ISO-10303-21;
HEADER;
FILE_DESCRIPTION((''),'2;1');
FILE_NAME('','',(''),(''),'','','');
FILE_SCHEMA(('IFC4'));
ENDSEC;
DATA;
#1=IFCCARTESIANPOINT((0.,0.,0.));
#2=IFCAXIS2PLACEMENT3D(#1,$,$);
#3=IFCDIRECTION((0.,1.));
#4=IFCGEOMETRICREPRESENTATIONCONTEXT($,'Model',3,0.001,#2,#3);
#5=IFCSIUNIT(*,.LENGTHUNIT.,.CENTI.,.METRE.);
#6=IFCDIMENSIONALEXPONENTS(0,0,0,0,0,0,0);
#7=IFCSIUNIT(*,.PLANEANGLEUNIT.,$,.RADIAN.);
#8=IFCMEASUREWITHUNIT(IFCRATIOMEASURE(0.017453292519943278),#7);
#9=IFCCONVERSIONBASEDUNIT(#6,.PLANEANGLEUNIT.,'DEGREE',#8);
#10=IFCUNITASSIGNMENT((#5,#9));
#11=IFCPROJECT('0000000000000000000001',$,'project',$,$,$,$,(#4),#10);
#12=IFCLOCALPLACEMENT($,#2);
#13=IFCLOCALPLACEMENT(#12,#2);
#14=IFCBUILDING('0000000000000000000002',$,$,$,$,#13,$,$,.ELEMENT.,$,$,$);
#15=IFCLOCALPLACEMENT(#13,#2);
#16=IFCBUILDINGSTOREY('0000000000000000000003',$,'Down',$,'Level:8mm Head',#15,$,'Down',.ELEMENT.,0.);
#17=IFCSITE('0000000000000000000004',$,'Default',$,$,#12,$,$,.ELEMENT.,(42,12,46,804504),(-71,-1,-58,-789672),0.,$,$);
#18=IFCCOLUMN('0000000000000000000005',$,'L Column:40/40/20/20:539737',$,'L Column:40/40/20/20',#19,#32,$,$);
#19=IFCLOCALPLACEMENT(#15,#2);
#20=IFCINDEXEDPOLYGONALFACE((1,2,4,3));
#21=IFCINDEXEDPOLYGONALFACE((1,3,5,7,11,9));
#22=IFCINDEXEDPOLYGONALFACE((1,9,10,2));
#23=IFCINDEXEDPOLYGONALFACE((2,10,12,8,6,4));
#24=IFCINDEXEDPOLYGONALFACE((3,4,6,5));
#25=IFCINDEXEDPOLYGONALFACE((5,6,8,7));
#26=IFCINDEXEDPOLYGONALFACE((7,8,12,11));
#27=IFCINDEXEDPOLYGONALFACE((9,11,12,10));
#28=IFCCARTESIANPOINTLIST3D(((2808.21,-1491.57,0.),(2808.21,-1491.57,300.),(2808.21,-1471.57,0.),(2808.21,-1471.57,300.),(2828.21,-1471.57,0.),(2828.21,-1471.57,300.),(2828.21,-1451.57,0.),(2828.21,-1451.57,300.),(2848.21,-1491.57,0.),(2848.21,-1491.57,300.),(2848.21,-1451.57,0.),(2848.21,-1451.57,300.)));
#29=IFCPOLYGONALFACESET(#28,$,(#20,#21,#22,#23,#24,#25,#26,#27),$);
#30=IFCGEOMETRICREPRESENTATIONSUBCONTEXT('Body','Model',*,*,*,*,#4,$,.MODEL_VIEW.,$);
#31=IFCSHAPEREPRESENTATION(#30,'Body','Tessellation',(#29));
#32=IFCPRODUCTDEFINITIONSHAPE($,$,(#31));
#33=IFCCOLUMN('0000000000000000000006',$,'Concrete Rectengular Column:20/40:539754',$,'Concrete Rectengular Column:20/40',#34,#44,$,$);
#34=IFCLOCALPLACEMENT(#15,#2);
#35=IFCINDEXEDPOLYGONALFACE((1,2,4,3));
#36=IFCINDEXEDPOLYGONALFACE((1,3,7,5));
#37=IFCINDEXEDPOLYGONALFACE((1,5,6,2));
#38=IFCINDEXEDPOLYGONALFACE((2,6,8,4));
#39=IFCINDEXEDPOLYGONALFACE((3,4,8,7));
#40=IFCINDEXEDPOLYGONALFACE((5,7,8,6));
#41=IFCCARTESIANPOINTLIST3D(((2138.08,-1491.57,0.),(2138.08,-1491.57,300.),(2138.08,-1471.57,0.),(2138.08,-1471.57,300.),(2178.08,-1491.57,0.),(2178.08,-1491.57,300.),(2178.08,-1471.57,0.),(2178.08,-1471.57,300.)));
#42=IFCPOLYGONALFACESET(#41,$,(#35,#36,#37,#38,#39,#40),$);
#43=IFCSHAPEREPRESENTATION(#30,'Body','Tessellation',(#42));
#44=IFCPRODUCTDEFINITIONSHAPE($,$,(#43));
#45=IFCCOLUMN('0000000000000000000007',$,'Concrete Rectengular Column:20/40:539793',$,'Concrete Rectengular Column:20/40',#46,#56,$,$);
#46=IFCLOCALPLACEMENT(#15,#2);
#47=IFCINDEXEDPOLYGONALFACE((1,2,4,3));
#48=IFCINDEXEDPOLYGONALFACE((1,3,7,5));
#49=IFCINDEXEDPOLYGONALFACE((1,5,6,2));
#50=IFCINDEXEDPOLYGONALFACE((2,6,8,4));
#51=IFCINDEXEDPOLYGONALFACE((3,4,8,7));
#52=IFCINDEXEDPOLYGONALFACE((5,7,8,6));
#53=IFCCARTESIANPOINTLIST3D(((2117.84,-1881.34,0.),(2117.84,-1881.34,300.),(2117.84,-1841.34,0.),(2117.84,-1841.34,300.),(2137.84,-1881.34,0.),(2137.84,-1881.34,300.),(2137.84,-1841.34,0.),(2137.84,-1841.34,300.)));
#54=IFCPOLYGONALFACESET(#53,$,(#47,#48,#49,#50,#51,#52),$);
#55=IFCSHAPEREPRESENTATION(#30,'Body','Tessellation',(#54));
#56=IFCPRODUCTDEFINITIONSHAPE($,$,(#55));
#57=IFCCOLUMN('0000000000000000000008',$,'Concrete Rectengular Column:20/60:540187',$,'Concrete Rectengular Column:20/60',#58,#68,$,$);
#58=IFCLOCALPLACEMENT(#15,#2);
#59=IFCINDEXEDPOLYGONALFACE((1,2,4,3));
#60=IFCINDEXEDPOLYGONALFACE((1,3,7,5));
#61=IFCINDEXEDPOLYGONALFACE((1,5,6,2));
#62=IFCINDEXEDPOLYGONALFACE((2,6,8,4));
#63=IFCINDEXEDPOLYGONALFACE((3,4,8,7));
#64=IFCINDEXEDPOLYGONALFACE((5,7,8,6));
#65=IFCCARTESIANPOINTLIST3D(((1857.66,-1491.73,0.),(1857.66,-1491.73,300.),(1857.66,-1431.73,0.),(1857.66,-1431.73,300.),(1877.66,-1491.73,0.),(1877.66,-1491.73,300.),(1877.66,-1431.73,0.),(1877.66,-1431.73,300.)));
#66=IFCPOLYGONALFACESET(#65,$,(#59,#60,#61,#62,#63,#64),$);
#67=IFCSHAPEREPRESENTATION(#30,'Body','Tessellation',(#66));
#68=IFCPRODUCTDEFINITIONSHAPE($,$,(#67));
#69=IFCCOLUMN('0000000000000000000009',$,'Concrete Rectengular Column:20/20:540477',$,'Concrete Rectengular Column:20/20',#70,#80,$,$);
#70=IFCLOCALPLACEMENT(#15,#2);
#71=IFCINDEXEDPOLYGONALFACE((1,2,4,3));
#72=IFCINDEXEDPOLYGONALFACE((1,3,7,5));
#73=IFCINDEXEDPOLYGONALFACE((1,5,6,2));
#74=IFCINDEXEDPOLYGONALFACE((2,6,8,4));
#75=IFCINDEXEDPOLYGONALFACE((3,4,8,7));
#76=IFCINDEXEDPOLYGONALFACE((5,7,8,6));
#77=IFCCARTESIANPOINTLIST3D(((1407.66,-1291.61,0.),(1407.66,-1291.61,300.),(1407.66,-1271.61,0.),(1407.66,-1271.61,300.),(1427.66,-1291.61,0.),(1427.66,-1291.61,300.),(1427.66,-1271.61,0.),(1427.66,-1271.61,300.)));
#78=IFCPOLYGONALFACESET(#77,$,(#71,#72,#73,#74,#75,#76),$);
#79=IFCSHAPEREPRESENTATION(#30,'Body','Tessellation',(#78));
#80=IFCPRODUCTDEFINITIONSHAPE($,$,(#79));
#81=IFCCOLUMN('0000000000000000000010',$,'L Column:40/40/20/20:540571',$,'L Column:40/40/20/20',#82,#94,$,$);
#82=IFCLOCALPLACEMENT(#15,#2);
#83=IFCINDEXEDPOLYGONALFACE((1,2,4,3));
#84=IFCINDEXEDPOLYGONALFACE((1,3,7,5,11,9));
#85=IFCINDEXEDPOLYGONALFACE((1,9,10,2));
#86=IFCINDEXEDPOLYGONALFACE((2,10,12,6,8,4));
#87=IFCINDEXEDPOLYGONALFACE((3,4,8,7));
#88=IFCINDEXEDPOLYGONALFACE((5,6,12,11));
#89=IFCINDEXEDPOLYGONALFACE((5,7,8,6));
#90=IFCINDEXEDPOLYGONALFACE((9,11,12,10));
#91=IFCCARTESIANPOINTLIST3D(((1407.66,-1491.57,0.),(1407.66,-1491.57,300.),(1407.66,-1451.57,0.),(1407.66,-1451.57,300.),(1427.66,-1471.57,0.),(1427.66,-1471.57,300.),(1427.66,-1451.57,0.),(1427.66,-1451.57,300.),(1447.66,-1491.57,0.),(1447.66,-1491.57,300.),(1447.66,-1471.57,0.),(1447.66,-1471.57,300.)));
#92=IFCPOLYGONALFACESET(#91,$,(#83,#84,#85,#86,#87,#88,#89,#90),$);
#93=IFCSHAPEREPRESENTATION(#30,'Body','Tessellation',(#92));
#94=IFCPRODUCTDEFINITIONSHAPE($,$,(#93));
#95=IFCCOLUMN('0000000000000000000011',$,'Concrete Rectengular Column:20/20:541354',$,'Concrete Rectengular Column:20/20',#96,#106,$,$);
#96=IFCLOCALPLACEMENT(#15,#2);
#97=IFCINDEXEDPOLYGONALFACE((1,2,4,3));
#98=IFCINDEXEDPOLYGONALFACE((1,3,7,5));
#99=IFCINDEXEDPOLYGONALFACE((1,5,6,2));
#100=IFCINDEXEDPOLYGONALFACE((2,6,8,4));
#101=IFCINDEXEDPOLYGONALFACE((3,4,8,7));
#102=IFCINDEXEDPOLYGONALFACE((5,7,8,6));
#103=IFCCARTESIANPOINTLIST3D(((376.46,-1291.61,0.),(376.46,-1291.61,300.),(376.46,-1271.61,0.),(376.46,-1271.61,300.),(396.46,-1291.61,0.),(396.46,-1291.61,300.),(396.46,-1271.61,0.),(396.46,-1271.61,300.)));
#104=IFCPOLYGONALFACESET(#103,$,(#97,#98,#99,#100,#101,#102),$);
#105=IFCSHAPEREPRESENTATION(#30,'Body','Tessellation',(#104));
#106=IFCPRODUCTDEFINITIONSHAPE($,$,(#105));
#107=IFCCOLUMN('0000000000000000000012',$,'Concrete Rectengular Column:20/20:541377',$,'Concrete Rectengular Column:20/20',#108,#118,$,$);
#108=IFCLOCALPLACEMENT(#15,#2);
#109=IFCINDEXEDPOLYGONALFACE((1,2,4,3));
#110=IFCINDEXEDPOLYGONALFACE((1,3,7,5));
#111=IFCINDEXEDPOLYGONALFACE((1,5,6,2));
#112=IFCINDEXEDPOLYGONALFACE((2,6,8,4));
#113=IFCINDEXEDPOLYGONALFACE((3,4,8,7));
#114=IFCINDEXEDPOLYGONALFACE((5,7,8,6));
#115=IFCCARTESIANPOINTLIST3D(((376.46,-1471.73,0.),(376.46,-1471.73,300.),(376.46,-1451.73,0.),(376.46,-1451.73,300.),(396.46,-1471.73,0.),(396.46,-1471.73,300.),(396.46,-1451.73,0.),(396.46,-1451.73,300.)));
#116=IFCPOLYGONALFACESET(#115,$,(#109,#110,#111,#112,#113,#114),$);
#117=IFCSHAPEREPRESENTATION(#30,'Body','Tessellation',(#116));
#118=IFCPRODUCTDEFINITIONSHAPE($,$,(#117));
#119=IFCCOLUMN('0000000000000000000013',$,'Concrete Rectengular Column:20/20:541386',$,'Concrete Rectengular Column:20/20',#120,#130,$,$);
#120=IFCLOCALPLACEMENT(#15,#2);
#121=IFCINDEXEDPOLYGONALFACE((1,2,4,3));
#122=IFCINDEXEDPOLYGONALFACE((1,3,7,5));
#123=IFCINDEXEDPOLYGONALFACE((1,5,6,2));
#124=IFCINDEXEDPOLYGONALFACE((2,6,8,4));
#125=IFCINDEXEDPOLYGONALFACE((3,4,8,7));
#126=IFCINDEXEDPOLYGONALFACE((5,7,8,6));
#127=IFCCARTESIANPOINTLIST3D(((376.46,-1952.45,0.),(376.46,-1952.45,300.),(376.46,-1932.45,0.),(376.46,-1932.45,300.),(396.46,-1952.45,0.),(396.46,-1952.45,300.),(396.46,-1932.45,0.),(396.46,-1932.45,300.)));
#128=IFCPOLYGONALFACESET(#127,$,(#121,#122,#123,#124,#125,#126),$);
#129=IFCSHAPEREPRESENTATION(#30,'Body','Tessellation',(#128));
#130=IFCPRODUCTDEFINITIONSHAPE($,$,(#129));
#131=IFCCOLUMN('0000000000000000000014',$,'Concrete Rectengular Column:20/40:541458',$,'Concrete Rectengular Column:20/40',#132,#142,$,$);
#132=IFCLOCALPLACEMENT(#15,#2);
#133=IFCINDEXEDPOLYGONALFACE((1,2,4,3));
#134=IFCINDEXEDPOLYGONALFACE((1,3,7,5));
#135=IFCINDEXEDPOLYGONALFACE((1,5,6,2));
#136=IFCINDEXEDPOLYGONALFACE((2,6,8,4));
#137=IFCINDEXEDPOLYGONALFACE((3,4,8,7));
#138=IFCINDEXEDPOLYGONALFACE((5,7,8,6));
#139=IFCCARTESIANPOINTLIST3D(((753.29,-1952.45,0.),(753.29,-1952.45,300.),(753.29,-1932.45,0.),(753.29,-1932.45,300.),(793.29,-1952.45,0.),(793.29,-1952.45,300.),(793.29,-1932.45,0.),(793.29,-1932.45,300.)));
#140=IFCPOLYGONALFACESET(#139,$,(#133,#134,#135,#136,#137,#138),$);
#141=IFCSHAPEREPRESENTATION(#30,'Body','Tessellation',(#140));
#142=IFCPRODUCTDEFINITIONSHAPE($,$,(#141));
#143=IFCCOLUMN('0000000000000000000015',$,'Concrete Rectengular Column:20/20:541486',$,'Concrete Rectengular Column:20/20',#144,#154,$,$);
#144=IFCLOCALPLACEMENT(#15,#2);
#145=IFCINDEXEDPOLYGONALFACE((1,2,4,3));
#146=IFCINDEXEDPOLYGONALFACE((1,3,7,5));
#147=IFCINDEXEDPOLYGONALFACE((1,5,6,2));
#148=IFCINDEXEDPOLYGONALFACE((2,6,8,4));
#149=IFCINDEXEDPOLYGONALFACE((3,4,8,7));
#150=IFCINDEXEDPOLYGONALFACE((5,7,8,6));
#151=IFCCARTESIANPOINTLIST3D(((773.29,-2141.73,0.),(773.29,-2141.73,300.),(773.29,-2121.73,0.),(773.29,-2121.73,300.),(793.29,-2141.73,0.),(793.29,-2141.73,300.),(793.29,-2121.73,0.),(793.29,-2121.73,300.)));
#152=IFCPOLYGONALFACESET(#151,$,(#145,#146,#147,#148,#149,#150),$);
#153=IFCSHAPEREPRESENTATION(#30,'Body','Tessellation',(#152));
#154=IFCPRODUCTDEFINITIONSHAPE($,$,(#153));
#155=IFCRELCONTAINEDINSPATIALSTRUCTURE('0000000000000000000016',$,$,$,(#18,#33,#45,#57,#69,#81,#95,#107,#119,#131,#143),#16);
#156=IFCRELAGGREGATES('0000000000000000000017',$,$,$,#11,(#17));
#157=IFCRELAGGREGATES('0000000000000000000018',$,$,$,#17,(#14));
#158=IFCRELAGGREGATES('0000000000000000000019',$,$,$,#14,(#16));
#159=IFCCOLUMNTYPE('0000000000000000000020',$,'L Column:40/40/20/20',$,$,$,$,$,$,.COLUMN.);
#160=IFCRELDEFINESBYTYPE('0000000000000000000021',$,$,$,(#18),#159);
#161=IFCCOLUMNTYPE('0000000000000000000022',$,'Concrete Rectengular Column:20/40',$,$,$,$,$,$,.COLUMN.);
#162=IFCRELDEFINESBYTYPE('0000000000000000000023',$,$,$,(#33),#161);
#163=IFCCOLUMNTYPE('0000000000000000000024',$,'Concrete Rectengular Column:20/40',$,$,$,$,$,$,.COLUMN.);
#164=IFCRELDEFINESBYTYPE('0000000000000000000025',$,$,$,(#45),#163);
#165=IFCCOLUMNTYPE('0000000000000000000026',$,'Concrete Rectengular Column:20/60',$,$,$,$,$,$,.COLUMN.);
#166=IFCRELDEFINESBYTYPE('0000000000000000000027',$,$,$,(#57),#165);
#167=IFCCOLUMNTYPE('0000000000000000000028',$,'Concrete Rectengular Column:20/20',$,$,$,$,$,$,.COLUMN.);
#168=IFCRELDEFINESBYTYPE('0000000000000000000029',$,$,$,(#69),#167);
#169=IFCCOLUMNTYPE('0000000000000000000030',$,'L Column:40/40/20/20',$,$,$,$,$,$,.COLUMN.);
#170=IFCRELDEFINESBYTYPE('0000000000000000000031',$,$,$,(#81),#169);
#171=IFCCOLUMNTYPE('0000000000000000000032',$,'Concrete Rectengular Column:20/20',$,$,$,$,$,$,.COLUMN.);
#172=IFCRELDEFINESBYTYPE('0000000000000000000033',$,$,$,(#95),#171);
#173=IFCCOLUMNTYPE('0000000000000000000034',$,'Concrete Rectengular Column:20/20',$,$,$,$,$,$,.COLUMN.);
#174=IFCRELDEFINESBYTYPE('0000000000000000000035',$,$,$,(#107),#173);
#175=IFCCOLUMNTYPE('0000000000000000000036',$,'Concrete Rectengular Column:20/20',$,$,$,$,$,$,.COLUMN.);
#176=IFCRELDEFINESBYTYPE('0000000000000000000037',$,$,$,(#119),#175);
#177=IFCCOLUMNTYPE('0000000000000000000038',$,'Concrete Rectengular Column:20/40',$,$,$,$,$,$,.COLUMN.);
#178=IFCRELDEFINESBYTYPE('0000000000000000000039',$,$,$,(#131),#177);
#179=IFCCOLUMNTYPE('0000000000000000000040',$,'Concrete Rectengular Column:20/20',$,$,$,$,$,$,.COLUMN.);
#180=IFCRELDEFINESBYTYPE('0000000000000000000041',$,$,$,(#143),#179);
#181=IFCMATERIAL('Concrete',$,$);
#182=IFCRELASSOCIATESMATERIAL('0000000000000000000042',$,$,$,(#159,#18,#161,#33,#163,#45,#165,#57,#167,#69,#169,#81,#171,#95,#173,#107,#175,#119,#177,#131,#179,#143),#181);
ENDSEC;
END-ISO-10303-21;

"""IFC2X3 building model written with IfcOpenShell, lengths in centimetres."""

from ifc_helpers import new_model, entity, si_unit, converted_unit, direction, frame, frame_2d, origin, origin_2d_with_axis, place, context, subcontext, project, spatial, polyline, rectangle, outline, extrude, source, transform, mapped, material, type_object, type_shapes, element, save


model = new_model("IFC2X3")

# Units and contexts
model_context = context("Model", 3, precision=0.001, world=origin(), true_north=direction((0.0, 1.0)))
body_context = subcontext(model_context, "Body", "Model", "MODEL_VIEW")
ifc_project = project(units=[si_unit("LENGTHUNIT", "METRE", prefix="CENTI"), converted_unit("PLANEANGLEUNIT", "DEGREE", entity("IfcRatioMeasure", 0.017453292519943278), si_unit("PLANEANGLEUNIT", "RADIAN"), dimensions=[0, 0, 0, 0, 0, 0, 0])], contexts=[model_context])

# Site, building, storey
site_placement = place(None, origin())
site = spatial("IfcSite", under=ifc_project, at=site_placement, Name="Default", CompositionType="ELEMENT", RefLatitude=(42, 12, 46, 804504), RefLongitude=(-71, -1, -58, -789672), RefElevation=0.0)
building_placement = place(site_placement, origin())
building = spatial("IfcBuilding", under=site, at=building_placement, CompositionType="ELEMENT")
storey_placement = place(building_placement, origin())
storey = spatial("IfcBuildingStorey", under=building, at=storey_placement, Name="Down", ObjectType="Level:8mm Head", LongName="Down", CompositionType="ELEMENT", Elevation=0.0)

# Columns
ifc_material = material(Name="Concrete")
column_type_1 = type_object("IfcColumnType", Name="L Column:40/40/20/20", PredefinedType="COLUMN", material=ifc_material)
shared_shape_1 = source(origin(), body_context, "Body", "SweptSolid", [
    extrude(outline(polyline([(0.0, -20.0), (20.0, -20.0), (20.0, 20.0), (-20.0, 20.0), (-20.0, 0.0), (0.0, 0.0), (0.0, -20.0)])), frame((2828.21, -1471.57, 0.0), z_axis=(0.0, 0.0, 1.0), x_axis=(0.0, -1.0, 0.0)), (0.0, 0.0, 1.0), 300.0),
])
type_shapes(column_type_1, [shared_shape_1])
column_1_placement = place(storey_placement, origin())
element("IfcColumn", 1, at=column_1_placement, inside=storey, type_object=column_type_1, material=ifc_material, Name="L Column:40/40/20/20:539737", ObjectType="L Column:40/40/20/20", context=body_context, shape_type="MappedRepresentation", body=[
    mapped(shared_shape_1, transform((0.0, 0.0, 0.0), scale=1.0)),
])
column_type_2 = type_object("IfcColumnType", Name="Concrete Rectengular Column:20/40", PredefinedType="COLUMN", material=ifc_material)
shared_shape_2 = source(origin(), body_context, "Body", "SweptSolid", [
    extrude(rectangle(XDim=20.0, YDim=40.0, at=frame_2d((0.0, 0.0), x_axis=(1.0, 0.0))), frame((2158.08, -1481.57, 0.0), z_axis=(0.0, 0.0, 1.0), x_axis=(0.0, -1.0, 0.0)), (0.0, 0.0, 1.0), 300.0),
])
type_shapes(column_type_2, [shared_shape_2])
column_2_placement = place(storey_placement, origin())
element("IfcColumn", 2, at=column_2_placement, inside=storey, type_object=column_type_2, material=ifc_material, Name="Concrete Rectengular Column:20/40:539754", ObjectType="Concrete Rectengular Column:20/40", context=body_context, shape_type="MappedRepresentation", body=[
    mapped(shared_shape_2, transform((0.0, 0.0, 0.0), scale=1.0)),
])
column_type_3 = type_object("IfcColumnType", Name="Concrete Rectengular Column:20/40", PredefinedType="COLUMN", material=ifc_material)
shared_shape_3 = source(origin(), body_context, "Body", "SweptSolid", [
    extrude(rectangle(XDim=40.0, YDim=20.0, at=frame_2d((0.0, 0.0), x_axis=(1.0, 0.0))), frame((2127.84, -1861.34, 0.0), z_axis=(0.0, 0.0, 1.0), x_axis=(0.0, -1.0, 0.0)), (0.0, 0.0, 1.0), 300.0),
])
type_shapes(column_type_3, [shared_shape_3])
column_3_placement = place(storey_placement, origin())
element("IfcColumn", 3, at=column_3_placement, inside=storey, type_object=column_type_3, material=ifc_material, Name="Concrete Rectengular Column:20/40:539793", ObjectType="Concrete Rectengular Column:20/40", context=body_context, shape_type="MappedRepresentation", body=[
    mapped(shared_shape_3, transform((0.0, 0.0, 0.0), scale=1.0)),
])
column_type_4 = type_object("IfcColumnType", Name="Concrete Rectengular Column:20/60", PredefinedType="COLUMN", material=ifc_material)
shared_shape_4 = source(origin(), body_context, "Body", "SweptSolid", [
    extrude(rectangle(XDim=60.0, YDim=20.0, at=frame_2d((0.0, 0.0), x_axis=(1.0, 0.0))), frame((1867.66, -1461.73, 0.0), z_axis=(0.0, 0.0, 1.0), x_axis=(0.0, -1.0, 0.0)), (0.0, 0.0, 1.0), 300.0),
])
type_shapes(column_type_4, [shared_shape_4])
column_4_placement = place(storey_placement, origin())
element("IfcColumn", 4, at=column_4_placement, inside=storey, type_object=column_type_4, material=ifc_material, Name="Concrete Rectengular Column:20/60:540187", ObjectType="Concrete Rectengular Column:20/60", context=body_context, shape_type="MappedRepresentation", body=[
    mapped(shared_shape_4, transform((0.0, 0.0, 0.0), scale=1.0)),
])
column_type_5 = type_object("IfcColumnType", Name="Concrete Rectengular Column:20/20", PredefinedType="COLUMN", material=ifc_material)
shared_shape_5 = source(origin(), body_context, "Body", "SweptSolid", [
    extrude(rectangle(XDim=20.0, YDim=20.0, at=frame_2d((0.0, 0.0), x_axis=(1.0, 0.0))), frame((1417.66, -1281.61, 0.0), z_axis=(0.0, 0.0, 1.0), x_axis=(0.0, -1.0, 0.0)), (0.0, 0.0, 1.0), 300.0),
])
type_shapes(column_type_5, [shared_shape_5])
column_5_placement = place(storey_placement, origin())
element("IfcColumn", 5, at=column_5_placement, inside=storey, type_object=column_type_5, material=ifc_material, Name="Concrete Rectengular Column:20/20:540477", ObjectType="Concrete Rectengular Column:20/20", context=body_context, shape_type="MappedRepresentation", body=[
    mapped(shared_shape_5, transform((0.0, 0.0, 0.0), scale=1.0)),
])
column_type_6 = type_object("IfcColumnType", Name="L Column:40/40/20/20", PredefinedType="COLUMN", material=ifc_material)
shared_shape_6 = source(origin(), body_context, "Body", "SweptSolid", [
    extrude(outline(polyline([(-20.0, -20.0), (20.0, -20.0), (20.0, 20.0), (0.0, 20.0), (0.0, 0.0), (-20.0, 0.0), (-20.0, -20.0)])), frame((1427.66, -1471.57, 0.0), z_axis=(0.0, 0.0, 1.0), x_axis=(0.0, -1.0, 0.0)), (0.0, 0.0, 1.0), 300.0),
])
type_shapes(column_type_6, [shared_shape_6])
column_6_placement = place(storey_placement, origin())
element("IfcColumn", 6, at=column_6_placement, inside=storey, type_object=column_type_6, material=ifc_material, Name="L Column:40/40/20/20:540571", ObjectType="L Column:40/40/20/20", context=body_context, shape_type="MappedRepresentation", body=[
    mapped(shared_shape_6, transform((0.0, 0.0, 0.0), scale=1.0)),
])
column_type_7 = type_object("IfcColumnType", Name="Concrete Rectengular Column:20/20", PredefinedType="COLUMN", material=ifc_material)
shared_shape_7 = source(origin(), body_context, "Body", "SweptSolid", [
    extrude(rectangle(XDim=20.0, YDim=20.0, at=frame_2d((0.0, 0.0), x_axis=(1.0, 0.0))), frame((386.46, -1281.61, 0.0), z_axis=(0.0, 0.0, 1.0), x_axis=(0.0, -1.0, 0.0)), (0.0, 0.0, 1.0), 300.0),
])
type_shapes(column_type_7, [shared_shape_7])
column_7_placement = place(storey_placement, origin())
element("IfcColumn", 7, at=column_7_placement, inside=storey, type_object=column_type_7, material=ifc_material, Name="Concrete Rectengular Column:20/20:541354", ObjectType="Concrete Rectengular Column:20/20", context=body_context, shape_type="MappedRepresentation", body=[
    mapped(shared_shape_7, transform((0.0, 0.0, 0.0), scale=1.0)),
])
column_type_8 = type_object("IfcColumnType", Name="Concrete Rectengular Column:20/20", PredefinedType="COLUMN", material=ifc_material)
shared_shape_8 = source(origin(), body_context, "Body", "SweptSolid", [
    extrude(rectangle(XDim=20.0, YDim=20.0, at=frame_2d((0.0, 0.0), x_axis=(1.0, 0.0))), frame((386.46, -1461.73, 0.0), z_axis=(0.0, 0.0, 1.0), x_axis=(0.0, -1.0, 0.0)), (0.0, 0.0, 1.0), 300.0),
])
type_shapes(column_type_8, [shared_shape_8])
column_8_placement = place(storey_placement, origin())
element("IfcColumn", 8, at=column_8_placement, inside=storey, type_object=column_type_8, material=ifc_material, Name="Concrete Rectengular Column:20/20:541377", ObjectType="Concrete Rectengular Column:20/20", context=body_context, shape_type="MappedRepresentation", body=[
    mapped(shared_shape_8, transform((0.0, 0.0, 0.0), scale=1.0)),
])
column_type_9 = type_object("IfcColumnType", Name="Concrete Rectengular Column:20/20", PredefinedType="COLUMN", material=ifc_material)
shared_shape_9 = source(origin(), body_context, "Body", "SweptSolid", [
    extrude(rectangle(XDim=20.0, YDim=20.0, at=frame_2d((0.0, 0.0), x_axis=(1.0, 0.0))), frame((386.46, -1942.45, 0.0), z_axis=(0.0, 0.0, 1.0), x_axis=(0.0, -1.0, 0.0)), (0.0, 0.0, 1.0), 300.0),
])
type_shapes(column_type_9, [shared_shape_9])
column_9_placement = place(storey_placement, origin())
element("IfcColumn", 9, at=column_9_placement, inside=storey, type_object=column_type_9, material=ifc_material, Name="Concrete Rectengular Column:20/20:541386", ObjectType="Concrete Rectengular Column:20/20", context=body_context, shape_type="MappedRepresentation", body=[
    mapped(shared_shape_9, transform((0.0, 0.0, 0.0), scale=1.0)),
])
column_type_10 = type_object("IfcColumnType", Name="Concrete Rectengular Column:20/40", PredefinedType="COLUMN", material=ifc_material)
shared_shape_10 = source(origin(), body_context, "Body", "SweptSolid", [
    extrude(rectangle(XDim=20.0, YDim=40.0, at=origin_2d_with_axis()), frame((773.29, -1942.45, 0.0), z_axis=(0.0, 0.0, 1.0), x_axis=(0.0, -1.0, 0.0)), (0.0, 0.0, 1.0), 300.0),
])
type_shapes(column_type_10, [shared_shape_10])
column_10_placement = place(storey_placement, origin())
element("IfcColumn", 10, at=column_10_placement, inside=storey, type_object=column_type_10, material=ifc_material, Name="Concrete Rectengular Column:20/40:541458", ObjectType="Concrete Rectengular Column:20/40", context=body_context, shape_type="MappedRepresentation", body=[
    mapped(shared_shape_10, transform((0.0, 0.0, 0.0), scale=1.0)),
])
column_type_11 = type_object("IfcColumnType", Name="Concrete Rectengular Column:20/20", PredefinedType="COLUMN", material=ifc_material)
shared_shape_11 = source(origin(), body_context, "Body", "SweptSolid", [
    extrude(rectangle(XDim=20.0, YDim=20.0, at=origin_2d_with_axis()), frame((783.29, -2131.73, 0.0), z_axis=(0.0, 0.0, 1.0), x_axis=(0.0, -1.0, 0.0)), (0.0, 0.0, 1.0), 300.0),
])
type_shapes(column_type_11, [shared_shape_11])
column_11_placement = place(storey_placement, origin())
element("IfcColumn", 11, at=column_11_placement, inside=storey, type_object=column_type_11, material=ifc_material, Name="Concrete Rectengular Column:20/20:541486", ObjectType="Concrete Rectengular Column:20/20", context=body_context, shape_type="MappedRepresentation", body=[
    mapped(shared_shape_11, transform((0.0, 0.0, 0.0), scale=1.0)),
])

save(model, "model.ifc")
